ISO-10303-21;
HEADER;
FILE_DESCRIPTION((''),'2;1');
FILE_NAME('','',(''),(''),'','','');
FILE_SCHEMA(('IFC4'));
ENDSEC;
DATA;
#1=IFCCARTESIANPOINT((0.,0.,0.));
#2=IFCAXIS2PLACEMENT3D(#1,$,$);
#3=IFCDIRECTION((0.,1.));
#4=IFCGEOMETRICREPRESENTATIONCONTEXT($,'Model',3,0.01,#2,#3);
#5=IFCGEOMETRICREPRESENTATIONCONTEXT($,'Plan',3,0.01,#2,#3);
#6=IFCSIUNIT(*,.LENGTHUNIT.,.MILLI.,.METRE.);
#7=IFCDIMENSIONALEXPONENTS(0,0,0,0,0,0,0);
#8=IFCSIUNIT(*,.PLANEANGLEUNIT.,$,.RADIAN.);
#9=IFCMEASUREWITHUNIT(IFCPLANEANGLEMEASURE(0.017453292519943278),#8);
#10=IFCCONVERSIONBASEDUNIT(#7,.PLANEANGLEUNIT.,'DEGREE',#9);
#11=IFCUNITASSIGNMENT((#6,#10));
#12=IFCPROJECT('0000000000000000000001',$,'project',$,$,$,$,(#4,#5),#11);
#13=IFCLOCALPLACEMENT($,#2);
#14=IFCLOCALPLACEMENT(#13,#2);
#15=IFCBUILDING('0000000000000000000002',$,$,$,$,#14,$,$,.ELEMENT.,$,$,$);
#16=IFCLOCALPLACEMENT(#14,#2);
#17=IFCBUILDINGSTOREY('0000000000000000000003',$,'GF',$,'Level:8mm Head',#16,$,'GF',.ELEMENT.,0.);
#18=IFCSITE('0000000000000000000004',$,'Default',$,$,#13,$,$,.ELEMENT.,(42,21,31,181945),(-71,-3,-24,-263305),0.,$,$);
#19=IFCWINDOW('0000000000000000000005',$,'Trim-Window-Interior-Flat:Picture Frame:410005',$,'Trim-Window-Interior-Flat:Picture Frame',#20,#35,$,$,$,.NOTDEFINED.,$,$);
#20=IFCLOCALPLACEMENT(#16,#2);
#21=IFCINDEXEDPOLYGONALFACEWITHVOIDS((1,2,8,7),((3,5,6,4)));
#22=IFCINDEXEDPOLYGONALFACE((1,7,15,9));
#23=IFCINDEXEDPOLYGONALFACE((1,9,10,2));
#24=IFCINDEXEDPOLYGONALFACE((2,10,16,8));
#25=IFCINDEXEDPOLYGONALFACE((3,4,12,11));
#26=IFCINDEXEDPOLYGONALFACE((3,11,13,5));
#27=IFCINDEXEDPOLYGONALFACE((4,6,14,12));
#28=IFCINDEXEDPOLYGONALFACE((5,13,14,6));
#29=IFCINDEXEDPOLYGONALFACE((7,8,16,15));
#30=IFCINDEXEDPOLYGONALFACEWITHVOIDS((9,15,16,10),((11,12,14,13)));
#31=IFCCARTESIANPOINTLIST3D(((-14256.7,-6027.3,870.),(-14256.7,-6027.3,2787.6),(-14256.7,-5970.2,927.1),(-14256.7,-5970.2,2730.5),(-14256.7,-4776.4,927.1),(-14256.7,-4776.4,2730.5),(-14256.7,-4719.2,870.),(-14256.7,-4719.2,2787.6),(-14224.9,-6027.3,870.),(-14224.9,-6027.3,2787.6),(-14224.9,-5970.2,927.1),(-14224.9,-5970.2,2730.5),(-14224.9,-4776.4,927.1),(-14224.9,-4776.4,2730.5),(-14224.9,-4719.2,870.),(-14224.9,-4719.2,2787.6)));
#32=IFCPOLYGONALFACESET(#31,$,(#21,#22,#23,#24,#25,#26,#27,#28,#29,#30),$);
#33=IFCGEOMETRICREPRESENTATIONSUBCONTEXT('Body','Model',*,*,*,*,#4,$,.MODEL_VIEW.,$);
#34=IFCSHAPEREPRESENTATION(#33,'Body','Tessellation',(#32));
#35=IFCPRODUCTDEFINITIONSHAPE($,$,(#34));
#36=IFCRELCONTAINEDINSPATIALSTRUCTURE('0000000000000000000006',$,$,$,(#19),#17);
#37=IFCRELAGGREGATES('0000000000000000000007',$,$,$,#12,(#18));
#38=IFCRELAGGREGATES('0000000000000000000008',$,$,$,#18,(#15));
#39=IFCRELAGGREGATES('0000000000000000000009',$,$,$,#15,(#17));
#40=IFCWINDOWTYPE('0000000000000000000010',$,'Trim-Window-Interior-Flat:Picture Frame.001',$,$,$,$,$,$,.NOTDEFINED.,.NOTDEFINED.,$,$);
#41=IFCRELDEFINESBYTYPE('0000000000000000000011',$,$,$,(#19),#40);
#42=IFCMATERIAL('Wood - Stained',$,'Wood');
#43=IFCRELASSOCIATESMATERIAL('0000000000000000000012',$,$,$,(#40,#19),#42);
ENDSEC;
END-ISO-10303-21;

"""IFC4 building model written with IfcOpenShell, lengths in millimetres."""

from ifc_helpers import new_model, entity, si_unit, converted_unit, direction, frame, origin, place, context, subcontext, project, spatial, indexed_curve, outline, extrude, source, transform, mapped, material, type_object, type_shapes, element, save


model = new_model("IFC4")

# Units and contexts
model_context = context("Model", 3, precision=0.01, world=origin(), true_north=direction((0.0, 1.0)))
plan_context = context("Plan", 3, precision=0.01, world=origin(), true_north=direction((0.0, 1.0)))
body_context = subcontext(model_context, "Body", "Model", "MODEL_VIEW")
ifc_project = project(units=[si_unit("LENGTHUNIT", "METRE", prefix="MILLI"), converted_unit("PLANEANGLEUNIT", "DEGREE", entity("IfcPlaneAngleMeasure", 0.017453292519943278), si_unit("PLANEANGLEUNIT", "RADIAN"), dimensions=[0, 0, 0, 0, 0, 0, 0])], contexts=[model_context, plan_context])

# Site, building, storey
site_placement = place(None, origin())
site = spatial("IfcSite", under=ifc_project, at=site_placement, Name="Default", CompositionType="ELEMENT", RefLatitude=(42, 21, 31, 181945), RefLongitude=(-71, -3, -24, -263305), RefElevation=0.0)
building_placement = place(site_placement, origin())
building = spatial("IfcBuilding", under=site, at=building_placement, CompositionType="ELEMENT")
storey_placement = place(building_placement, origin())
storey = spatial("IfcBuildingStorey", under=building, at=storey_placement, Name="GF", ObjectType="Level:8mm Head", LongName="GF", CompositionType="ELEMENT", Elevation=0.0)

# Window
ifc_material_1 = material(Name="Wood - Stained", Category="Wood")
window_type = type_object("IfcWindowType", Name="Trim-Window-Interior-Flat:Picture Frame.001", PredefinedType="NOTDEFINED", material=ifc_material_1)
shared_shape_1 = source(origin(), body_context, "Body", "SweptSolid", [
    extrude(outline(indexed_curve([(-654.0, -958.8), (654.0, -958.8), (654.0, 958.8), (-654.0, 958.8), (-654.0, -958.8)], self_intersect=False), holes=[indexed_curve([(-596.9, -901.7), (-596.9, 901.7), (596.9, 901.7), (596.9, -901.7), (-596.9, -901.7)], self_intersect=False)]), frame((0.0, -914.4, 0.0), z_axis=(0.0, 0.0, 1.0), x_axis=(-1.0, 0.0, 0.0)), (0.0, 0.0, 1.0), 31.7),
])
type_shapes(window_type, [shared_shape_1])
window_placement = place(storey_placement, frame((-14256.7, -5373.3, 2743.2), z_axis=(1.0, 0.0, 0.0), x_axis=(0.0, 1.0, 0.0)))
element("IfcWindow", 1, at=window_placement, inside=storey, type_object=window_type, material=ifc_material_1, Name="Trim-Window-Interior-Flat:Picture Frame:410005", ObjectType="Trim-Window-Interior-Flat:Picture Frame", PredefinedType="NOTDEFINED", context=body_context, shape_type="MappedRepresentation", body=[
    mapped(shared_shape_1, transform((0.0, 0.0, 0.0), scale=1.0)),
])

save(model, "model.ifc")
